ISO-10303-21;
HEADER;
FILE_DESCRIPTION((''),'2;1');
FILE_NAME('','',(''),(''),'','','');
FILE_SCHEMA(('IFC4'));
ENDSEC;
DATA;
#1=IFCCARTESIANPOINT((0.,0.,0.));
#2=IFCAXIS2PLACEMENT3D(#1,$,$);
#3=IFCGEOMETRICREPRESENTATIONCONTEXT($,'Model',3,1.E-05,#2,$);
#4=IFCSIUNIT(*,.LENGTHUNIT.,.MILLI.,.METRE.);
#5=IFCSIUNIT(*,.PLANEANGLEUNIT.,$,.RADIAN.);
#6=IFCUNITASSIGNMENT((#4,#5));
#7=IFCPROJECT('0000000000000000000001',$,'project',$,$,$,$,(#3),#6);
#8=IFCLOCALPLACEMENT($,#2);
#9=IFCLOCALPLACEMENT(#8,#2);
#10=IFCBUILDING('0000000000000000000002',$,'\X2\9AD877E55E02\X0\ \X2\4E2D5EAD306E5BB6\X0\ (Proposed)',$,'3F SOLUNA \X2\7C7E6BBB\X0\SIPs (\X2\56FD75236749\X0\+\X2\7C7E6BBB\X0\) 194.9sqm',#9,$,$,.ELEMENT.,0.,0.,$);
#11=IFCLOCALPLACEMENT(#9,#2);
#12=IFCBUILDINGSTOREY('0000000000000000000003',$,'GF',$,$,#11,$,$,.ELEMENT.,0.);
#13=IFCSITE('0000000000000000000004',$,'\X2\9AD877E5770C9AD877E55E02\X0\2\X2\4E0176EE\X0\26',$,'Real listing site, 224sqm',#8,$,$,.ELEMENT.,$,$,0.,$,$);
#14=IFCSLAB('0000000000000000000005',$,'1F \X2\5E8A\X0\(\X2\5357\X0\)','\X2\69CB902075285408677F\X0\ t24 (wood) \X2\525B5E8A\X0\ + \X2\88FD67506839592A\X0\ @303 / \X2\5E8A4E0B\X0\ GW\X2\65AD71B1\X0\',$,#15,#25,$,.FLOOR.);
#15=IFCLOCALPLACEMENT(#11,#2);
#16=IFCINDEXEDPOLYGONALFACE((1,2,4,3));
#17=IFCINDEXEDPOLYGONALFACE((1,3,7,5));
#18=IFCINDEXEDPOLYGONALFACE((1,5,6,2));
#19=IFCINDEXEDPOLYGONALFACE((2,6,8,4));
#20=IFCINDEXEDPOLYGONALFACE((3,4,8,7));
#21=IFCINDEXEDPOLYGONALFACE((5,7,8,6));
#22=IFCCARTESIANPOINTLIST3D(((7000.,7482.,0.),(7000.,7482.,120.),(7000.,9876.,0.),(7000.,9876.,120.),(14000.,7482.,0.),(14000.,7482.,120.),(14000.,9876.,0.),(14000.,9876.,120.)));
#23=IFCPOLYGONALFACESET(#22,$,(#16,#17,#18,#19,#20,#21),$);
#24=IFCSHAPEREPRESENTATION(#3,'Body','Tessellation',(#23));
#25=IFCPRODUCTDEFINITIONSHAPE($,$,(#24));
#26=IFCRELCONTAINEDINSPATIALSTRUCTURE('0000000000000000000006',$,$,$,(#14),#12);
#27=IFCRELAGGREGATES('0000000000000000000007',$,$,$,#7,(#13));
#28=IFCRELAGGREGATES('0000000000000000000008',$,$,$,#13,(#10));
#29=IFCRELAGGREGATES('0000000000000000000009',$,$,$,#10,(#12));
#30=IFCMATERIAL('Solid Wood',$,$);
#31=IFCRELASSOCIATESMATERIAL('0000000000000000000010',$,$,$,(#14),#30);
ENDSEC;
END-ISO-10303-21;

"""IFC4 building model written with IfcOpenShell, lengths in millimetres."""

from ifc_helpers import new_model, si_unit, frame, frame_2d, origin, place, context, project, spatial, rectangle, extrude, material, element, save


model = new_model("IFC4")

# Units and contexts
model_context = context("Model", 3, precision=1e-05, world=origin())
ifc_project = project(units=[si_unit("LENGTHUNIT", "METRE", prefix="MILLI"), si_unit("PLANEANGLEUNIT", "RADIAN")], contexts=[model_context])

# Site, building, storey
site_placement = place(None, origin())
site = spatial("IfcSite", under=ifc_project, at=site_placement, Name="高知県高知市2丁目26", ObjectType="Real listing site, 224sqm", CompositionType="ELEMENT", RefElevation=0.0)
building_placement = place(site_placement, origin())
building = spatial("IfcBuilding", under=site, at=building_placement, Name="高知市 中庭の家 (Proposed)", ObjectType="3F SOLUNA 籾殻SIPs (国産杉+籾殻) 194.9sqm", CompositionType="ELEMENT", ElevationOfRefHeight=0.0, ElevationOfTerrain=0.0)
storey_placement = place(building_placement, origin())
storey = spatial("IfcBuildingStorey", under=building, at=storey_placement, Name="GF", CompositionType="ELEMENT", Elevation=0.0)

# Slab
ifc_material_1 = material(Name="Solid Wood")
slab_1_placement = place(storey_placement, frame((3500.0, 3741.0, 0.0)))
element("IfcSlab", 1, at=slab_1_placement, inside=storey, material=ifc_material_1, Name="1F 床(南)", Description="構造用合板 t24 (wood) 剛床 + 製材根太 @303 / 床下 GW断熱", PredefinedType="FLOOR", context=model_context, shape_type="SweptSolid", body=[
    extrude(rectangle(XDim=7000.0, YDim=2394.0, at=frame_2d((3500.0, 1197.0))), frame((3500.0, 3741.0, 0.0)), (0.0, 0.0, 1.0), 120.0),
])

save(model, "model.ifc")
